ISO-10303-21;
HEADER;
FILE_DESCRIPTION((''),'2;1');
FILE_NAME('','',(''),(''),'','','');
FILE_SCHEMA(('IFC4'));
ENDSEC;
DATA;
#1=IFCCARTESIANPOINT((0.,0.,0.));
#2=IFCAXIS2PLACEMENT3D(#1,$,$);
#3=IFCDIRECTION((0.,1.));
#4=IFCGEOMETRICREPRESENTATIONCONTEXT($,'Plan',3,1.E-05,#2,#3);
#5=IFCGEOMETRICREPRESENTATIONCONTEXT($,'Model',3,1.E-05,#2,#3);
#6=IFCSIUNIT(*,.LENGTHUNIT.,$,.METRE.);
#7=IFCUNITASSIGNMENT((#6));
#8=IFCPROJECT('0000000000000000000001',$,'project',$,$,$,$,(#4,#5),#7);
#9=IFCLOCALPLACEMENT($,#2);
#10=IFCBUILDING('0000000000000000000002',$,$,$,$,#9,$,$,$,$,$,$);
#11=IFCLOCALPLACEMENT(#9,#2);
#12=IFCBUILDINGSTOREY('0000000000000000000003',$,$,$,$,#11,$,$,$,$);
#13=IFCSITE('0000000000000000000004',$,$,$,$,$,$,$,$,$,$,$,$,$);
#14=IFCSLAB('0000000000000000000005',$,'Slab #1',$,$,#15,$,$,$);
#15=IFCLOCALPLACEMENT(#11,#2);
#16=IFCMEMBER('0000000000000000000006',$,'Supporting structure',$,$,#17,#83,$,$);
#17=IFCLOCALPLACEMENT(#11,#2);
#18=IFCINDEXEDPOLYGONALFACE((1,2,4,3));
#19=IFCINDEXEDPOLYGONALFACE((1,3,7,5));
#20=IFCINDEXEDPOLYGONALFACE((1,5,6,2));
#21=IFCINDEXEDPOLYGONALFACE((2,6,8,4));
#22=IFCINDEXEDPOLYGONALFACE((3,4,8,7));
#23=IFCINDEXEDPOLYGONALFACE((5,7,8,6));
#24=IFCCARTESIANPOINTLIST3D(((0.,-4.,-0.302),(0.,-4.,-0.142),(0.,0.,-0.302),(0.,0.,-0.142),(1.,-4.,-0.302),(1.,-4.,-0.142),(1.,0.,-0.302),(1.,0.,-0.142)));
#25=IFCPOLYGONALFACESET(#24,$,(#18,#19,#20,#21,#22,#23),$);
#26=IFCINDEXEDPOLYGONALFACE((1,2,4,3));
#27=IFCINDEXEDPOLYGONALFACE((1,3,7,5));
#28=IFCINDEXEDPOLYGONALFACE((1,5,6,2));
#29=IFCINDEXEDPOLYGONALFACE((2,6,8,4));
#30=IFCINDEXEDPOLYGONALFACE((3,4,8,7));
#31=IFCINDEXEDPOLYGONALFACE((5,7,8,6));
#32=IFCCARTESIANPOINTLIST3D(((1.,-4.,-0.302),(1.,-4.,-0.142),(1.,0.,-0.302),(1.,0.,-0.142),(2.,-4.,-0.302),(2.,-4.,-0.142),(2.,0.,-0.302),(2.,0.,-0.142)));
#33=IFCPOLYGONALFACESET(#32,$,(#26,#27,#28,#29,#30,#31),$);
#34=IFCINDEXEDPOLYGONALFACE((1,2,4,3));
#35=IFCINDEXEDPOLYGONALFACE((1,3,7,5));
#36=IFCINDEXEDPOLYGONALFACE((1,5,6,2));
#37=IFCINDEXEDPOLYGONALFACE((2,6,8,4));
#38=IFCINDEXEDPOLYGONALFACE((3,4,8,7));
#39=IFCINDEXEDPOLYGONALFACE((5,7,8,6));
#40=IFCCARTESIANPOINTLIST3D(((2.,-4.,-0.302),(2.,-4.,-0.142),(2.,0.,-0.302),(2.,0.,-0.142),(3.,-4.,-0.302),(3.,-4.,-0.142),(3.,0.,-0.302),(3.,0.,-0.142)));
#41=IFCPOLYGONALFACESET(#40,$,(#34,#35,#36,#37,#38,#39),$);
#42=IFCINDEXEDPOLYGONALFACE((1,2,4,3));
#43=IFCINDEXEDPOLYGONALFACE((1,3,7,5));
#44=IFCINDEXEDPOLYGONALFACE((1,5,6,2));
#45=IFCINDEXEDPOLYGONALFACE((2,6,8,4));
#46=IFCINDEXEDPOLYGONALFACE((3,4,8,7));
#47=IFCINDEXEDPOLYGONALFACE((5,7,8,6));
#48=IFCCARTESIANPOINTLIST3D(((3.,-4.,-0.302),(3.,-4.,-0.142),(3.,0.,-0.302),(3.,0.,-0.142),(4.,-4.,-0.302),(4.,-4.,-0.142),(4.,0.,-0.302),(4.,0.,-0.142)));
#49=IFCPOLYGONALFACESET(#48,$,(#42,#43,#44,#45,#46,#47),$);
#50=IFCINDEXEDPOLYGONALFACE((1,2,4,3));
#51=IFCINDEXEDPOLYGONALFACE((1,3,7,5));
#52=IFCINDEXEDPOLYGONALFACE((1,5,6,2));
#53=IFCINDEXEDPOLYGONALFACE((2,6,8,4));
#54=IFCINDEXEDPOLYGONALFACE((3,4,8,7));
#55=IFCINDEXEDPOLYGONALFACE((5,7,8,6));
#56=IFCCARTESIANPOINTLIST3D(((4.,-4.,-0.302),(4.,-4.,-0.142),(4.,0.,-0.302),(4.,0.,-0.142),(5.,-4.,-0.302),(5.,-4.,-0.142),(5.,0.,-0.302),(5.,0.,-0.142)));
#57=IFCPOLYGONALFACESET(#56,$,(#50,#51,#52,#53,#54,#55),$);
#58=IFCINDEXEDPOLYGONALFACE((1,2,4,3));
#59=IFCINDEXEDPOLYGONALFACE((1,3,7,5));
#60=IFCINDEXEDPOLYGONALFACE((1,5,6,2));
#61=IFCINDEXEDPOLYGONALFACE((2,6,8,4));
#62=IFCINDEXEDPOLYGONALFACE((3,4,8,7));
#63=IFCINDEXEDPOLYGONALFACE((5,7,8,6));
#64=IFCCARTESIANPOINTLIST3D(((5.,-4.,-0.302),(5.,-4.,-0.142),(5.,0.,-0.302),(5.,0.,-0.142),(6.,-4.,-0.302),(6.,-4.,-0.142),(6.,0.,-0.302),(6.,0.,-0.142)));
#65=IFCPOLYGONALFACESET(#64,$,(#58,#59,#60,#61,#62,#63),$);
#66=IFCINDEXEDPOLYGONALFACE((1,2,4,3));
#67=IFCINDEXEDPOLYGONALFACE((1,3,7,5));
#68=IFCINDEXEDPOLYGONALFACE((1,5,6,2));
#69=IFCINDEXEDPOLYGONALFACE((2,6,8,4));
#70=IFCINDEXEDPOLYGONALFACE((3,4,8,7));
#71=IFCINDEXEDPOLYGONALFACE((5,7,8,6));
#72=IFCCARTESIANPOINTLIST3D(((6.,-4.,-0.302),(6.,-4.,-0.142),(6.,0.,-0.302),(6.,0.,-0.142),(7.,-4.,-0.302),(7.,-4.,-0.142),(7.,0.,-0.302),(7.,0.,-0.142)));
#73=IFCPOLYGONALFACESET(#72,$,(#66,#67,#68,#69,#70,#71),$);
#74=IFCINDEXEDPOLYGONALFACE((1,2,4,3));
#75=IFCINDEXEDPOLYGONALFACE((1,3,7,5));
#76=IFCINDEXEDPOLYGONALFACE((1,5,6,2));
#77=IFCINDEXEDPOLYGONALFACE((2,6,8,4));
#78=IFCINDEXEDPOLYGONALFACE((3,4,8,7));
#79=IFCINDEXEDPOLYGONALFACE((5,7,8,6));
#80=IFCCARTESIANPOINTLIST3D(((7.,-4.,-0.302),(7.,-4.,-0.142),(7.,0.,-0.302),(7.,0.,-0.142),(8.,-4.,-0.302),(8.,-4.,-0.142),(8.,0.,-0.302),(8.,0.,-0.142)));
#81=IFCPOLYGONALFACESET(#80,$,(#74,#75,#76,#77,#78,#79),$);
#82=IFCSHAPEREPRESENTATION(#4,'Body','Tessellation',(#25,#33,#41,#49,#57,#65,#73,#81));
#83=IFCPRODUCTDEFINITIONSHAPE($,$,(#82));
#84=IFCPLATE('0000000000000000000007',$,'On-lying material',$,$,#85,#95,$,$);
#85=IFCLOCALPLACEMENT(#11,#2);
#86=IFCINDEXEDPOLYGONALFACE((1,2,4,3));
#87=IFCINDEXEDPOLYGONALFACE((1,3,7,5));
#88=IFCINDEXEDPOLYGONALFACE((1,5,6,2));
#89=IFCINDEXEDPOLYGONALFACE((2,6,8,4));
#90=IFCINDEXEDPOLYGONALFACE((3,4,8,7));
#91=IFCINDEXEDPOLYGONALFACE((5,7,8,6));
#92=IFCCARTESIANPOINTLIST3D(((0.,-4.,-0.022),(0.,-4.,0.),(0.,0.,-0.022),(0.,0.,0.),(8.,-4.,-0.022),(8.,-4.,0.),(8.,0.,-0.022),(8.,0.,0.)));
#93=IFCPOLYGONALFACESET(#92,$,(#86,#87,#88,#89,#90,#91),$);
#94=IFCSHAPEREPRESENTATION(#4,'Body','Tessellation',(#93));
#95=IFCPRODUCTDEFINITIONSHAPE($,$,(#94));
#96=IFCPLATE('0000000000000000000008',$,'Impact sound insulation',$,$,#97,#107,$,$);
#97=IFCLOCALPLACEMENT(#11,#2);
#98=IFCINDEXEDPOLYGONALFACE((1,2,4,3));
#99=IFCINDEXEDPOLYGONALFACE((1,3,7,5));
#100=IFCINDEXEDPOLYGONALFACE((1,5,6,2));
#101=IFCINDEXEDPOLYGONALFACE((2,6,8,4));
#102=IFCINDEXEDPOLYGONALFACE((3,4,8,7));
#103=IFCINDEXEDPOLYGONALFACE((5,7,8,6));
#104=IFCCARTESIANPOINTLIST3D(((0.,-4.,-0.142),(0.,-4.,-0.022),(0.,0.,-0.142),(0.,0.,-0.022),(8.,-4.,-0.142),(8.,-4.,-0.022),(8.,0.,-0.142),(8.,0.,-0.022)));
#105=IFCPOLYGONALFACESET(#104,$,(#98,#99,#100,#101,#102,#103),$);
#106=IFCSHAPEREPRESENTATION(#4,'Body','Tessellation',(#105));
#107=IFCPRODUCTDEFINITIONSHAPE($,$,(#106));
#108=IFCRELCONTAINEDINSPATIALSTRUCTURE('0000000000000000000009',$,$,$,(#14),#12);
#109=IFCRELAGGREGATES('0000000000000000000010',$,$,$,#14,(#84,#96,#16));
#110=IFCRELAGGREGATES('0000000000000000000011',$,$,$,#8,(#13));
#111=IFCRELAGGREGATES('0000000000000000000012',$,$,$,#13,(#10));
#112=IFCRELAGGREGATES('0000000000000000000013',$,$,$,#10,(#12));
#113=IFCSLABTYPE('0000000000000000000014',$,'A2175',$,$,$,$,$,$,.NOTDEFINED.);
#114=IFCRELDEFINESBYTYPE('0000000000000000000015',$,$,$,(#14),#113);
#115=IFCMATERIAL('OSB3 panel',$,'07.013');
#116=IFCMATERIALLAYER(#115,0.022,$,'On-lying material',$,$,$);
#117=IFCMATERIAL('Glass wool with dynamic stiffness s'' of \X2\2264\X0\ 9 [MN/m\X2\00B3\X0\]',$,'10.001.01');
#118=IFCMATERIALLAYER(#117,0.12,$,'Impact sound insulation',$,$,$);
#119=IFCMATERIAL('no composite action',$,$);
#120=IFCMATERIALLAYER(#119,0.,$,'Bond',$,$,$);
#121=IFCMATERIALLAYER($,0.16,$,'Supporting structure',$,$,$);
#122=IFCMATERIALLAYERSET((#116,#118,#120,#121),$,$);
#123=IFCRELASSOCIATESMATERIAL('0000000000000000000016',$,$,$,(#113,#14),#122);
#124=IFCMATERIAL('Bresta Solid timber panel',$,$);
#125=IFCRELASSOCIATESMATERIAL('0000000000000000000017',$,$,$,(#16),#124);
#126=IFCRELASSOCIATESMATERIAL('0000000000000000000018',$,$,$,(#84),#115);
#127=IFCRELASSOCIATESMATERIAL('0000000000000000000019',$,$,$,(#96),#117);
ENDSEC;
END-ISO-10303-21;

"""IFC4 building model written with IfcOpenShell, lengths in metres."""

from ifc_helpers import new_model, si_unit, direction, frame, frame_2d, origin, origin_with_axes, place, context, project, spatial, rectangle, extrude, material, layer, layer_set, type_object, element, aggregate, save


model = new_model("IFC4")

# Units and contexts
plan_context = context("Plan", 3, precision=1e-05, world=origin(), true_north=direction((0.0, 1.0)))
model_context = context("Model", 3, precision=1e-05, world=origin(), true_north=direction((0.0, 1.0)))
ifc_project = project(units=[si_unit("LENGTHUNIT", "METRE")], contexts=[plan_context, model_context])

# Site, building, storey
site = spatial("IfcSite", under=ifc_project)
building_placement = place(None, origin())
building = spatial("IfcBuilding", under=site, at=building_placement)
storey_placement = place(building_placement, origin())
storey = spatial("IfcBuildingStorey", under=building, at=storey_placement)

# Slab, member, plates
ifc_material_1 = material(Name="OSB3 panel", Category="07.013")
ifc_layer_1 = layer(ifc_material_1, 0.022, Name="On-lying material")
ifc_material_2 = material(Name="Glass wool with dynamic stiffness s' of ≤ 9 [MN/m³]", Category="10.001.01")
ifc_layer_2 = layer(ifc_material_2, 0.12, Name="Impact sound insulation")
ifc_material_3 = material(Name="no composite action")
ifc_layer_3 = layer(ifc_material_3, 0.0, Name="Bond")
ifc_layer_4 = layer(None, 0.16, Name="Supporting structure")
ifc_layer_set = layer_set([ifc_layer_1, ifc_layer_2, ifc_layer_3, ifc_layer_4])
slab_type = type_object("IfcSlabType", Name="A2175", PredefinedType="NOTDEFINED", material=ifc_layer_set)
slab_placement = place(None, frame((0.0, 0.0, 0.0), z_axis=(0.0, 0.0, -1.0), x_axis=(1.0, 0.0, 0.0)))
slab = element("IfcSlab", 1, at=slab_placement, inside=storey, type_object=slab_type, material=ifc_layer_set, Name="Slab #1")
ifc_material_4 = material(Name="Bresta Solid timber panel")
member_placement = place(slab_placement, origin())
member = element("IfcMember", 2, at=member_placement, material=ifc_material_4, Name="Supporting structure", context=plan_context, shape_type="SweptSolid", body=[
    extrude(rectangle(XDim=1.0, YDim=0.16, at=frame_2d((0.5, 0.08), x_axis=(1.0, 0.0))), frame((0.0, 4.0, 0.142), z_axis=(0.0, -1.0, 0.0), x_axis=(1.0, 0.0, 0.0)), (0.0, 0.0, 1.0), 4.0),
    extrude(rectangle(XDim=1.0, YDim=0.16, at=frame_2d((0.5, 0.08), x_axis=(1.0, 0.0))), frame((1.0, 4.0, 0.142), z_axis=(0.0, -1.0, 0.0), x_axis=(1.0, 0.0, 0.0)), (0.0, 0.0, 1.0), 4.0),
    extrude(rectangle(XDim=1.0, YDim=0.16, at=frame_2d((0.5, 0.08), x_axis=(1.0, 0.0))), frame((2.0, 4.0, 0.142), z_axis=(0.0, -1.0, 0.0), x_axis=(1.0, 0.0, 0.0)), (0.0, 0.0, 1.0), 4.0),
    extrude(rectangle(XDim=1.0, YDim=0.16, at=frame_2d((0.5, 0.08), x_axis=(1.0, 0.0))), frame((3.0, 4.0, 0.142), z_axis=(0.0, -1.0, 0.0), x_axis=(1.0, 0.0, 0.0)), (0.0, 0.0, 1.0), 4.0),
    extrude(rectangle(XDim=1.0, YDim=0.16, at=frame_2d((0.5, 0.08), x_axis=(1.0, 0.0))), frame((4.0, 4.0, 0.142), z_axis=(0.0, -1.0, 0.0), x_axis=(1.0, 0.0, 0.0)), (0.0, 0.0, 1.0), 4.0),
    extrude(rectangle(XDim=1.0, YDim=0.16, at=frame_2d((0.5, 0.08), x_axis=(1.0, 0.0))), frame((5.0, 4.0, 0.142), z_axis=(0.0, -1.0, 0.0), x_axis=(1.0, 0.0, 0.0)), (0.0, 0.0, 1.0), 4.0),
    extrude(rectangle(XDim=1.0, YDim=0.16, at=frame_2d((0.5, 0.08), x_axis=(1.0, 0.0))), frame((6.0, 4.0, 0.142), z_axis=(0.0, -1.0, 0.0), x_axis=(1.0, 0.0, 0.0)), (0.0, 0.0, 1.0), 4.0),
    extrude(rectangle(XDim=1.0, YDim=0.16, at=frame_2d((0.5, 0.08), x_axis=(1.0, 0.0))), frame((7.0, 4.0, 0.142), z_axis=(0.0, -1.0, 0.0), x_axis=(1.0, 0.0, 0.0)), (0.0, 0.0, 1.0), 4.0),
])
plate_1_placement = place(slab_placement, origin())
plate_1 = element("IfcPlate", 3, at=plate_1_placement, material=ifc_material_1, Name="On-lying material", context=plan_context, shape_type="SweptSolid", body=[
    extrude(rectangle(XDim=8.0, YDim=4.0, at=frame_2d((4.0, 2.0), x_axis=(1.0, 0.0))), origin_with_axes(), (0.0, 0.0, 1.0), 0.022),
])
plate_2_placement = place(slab_placement, origin())
plate_2 = element("IfcPlate", 4, at=plate_2_placement, material=ifc_material_2, Name="Impact sound insulation", context=plan_context, shape_type="SweptSolid", body=[
    extrude(rectangle(XDim=8.0, YDim=4.0, at=frame_2d((4.0, 2.0), x_axis=(1.0, 0.0))), frame((0.0, 0.0, 0.022), z_axis=(0.0, 0.0, 1.0), x_axis=(1.0, 0.0, 0.0)), (0.0, 0.0, 1.0), 0.12),
])
aggregate(slab, [plate_1, plate_2, member])

save(model, "model.ifc")
